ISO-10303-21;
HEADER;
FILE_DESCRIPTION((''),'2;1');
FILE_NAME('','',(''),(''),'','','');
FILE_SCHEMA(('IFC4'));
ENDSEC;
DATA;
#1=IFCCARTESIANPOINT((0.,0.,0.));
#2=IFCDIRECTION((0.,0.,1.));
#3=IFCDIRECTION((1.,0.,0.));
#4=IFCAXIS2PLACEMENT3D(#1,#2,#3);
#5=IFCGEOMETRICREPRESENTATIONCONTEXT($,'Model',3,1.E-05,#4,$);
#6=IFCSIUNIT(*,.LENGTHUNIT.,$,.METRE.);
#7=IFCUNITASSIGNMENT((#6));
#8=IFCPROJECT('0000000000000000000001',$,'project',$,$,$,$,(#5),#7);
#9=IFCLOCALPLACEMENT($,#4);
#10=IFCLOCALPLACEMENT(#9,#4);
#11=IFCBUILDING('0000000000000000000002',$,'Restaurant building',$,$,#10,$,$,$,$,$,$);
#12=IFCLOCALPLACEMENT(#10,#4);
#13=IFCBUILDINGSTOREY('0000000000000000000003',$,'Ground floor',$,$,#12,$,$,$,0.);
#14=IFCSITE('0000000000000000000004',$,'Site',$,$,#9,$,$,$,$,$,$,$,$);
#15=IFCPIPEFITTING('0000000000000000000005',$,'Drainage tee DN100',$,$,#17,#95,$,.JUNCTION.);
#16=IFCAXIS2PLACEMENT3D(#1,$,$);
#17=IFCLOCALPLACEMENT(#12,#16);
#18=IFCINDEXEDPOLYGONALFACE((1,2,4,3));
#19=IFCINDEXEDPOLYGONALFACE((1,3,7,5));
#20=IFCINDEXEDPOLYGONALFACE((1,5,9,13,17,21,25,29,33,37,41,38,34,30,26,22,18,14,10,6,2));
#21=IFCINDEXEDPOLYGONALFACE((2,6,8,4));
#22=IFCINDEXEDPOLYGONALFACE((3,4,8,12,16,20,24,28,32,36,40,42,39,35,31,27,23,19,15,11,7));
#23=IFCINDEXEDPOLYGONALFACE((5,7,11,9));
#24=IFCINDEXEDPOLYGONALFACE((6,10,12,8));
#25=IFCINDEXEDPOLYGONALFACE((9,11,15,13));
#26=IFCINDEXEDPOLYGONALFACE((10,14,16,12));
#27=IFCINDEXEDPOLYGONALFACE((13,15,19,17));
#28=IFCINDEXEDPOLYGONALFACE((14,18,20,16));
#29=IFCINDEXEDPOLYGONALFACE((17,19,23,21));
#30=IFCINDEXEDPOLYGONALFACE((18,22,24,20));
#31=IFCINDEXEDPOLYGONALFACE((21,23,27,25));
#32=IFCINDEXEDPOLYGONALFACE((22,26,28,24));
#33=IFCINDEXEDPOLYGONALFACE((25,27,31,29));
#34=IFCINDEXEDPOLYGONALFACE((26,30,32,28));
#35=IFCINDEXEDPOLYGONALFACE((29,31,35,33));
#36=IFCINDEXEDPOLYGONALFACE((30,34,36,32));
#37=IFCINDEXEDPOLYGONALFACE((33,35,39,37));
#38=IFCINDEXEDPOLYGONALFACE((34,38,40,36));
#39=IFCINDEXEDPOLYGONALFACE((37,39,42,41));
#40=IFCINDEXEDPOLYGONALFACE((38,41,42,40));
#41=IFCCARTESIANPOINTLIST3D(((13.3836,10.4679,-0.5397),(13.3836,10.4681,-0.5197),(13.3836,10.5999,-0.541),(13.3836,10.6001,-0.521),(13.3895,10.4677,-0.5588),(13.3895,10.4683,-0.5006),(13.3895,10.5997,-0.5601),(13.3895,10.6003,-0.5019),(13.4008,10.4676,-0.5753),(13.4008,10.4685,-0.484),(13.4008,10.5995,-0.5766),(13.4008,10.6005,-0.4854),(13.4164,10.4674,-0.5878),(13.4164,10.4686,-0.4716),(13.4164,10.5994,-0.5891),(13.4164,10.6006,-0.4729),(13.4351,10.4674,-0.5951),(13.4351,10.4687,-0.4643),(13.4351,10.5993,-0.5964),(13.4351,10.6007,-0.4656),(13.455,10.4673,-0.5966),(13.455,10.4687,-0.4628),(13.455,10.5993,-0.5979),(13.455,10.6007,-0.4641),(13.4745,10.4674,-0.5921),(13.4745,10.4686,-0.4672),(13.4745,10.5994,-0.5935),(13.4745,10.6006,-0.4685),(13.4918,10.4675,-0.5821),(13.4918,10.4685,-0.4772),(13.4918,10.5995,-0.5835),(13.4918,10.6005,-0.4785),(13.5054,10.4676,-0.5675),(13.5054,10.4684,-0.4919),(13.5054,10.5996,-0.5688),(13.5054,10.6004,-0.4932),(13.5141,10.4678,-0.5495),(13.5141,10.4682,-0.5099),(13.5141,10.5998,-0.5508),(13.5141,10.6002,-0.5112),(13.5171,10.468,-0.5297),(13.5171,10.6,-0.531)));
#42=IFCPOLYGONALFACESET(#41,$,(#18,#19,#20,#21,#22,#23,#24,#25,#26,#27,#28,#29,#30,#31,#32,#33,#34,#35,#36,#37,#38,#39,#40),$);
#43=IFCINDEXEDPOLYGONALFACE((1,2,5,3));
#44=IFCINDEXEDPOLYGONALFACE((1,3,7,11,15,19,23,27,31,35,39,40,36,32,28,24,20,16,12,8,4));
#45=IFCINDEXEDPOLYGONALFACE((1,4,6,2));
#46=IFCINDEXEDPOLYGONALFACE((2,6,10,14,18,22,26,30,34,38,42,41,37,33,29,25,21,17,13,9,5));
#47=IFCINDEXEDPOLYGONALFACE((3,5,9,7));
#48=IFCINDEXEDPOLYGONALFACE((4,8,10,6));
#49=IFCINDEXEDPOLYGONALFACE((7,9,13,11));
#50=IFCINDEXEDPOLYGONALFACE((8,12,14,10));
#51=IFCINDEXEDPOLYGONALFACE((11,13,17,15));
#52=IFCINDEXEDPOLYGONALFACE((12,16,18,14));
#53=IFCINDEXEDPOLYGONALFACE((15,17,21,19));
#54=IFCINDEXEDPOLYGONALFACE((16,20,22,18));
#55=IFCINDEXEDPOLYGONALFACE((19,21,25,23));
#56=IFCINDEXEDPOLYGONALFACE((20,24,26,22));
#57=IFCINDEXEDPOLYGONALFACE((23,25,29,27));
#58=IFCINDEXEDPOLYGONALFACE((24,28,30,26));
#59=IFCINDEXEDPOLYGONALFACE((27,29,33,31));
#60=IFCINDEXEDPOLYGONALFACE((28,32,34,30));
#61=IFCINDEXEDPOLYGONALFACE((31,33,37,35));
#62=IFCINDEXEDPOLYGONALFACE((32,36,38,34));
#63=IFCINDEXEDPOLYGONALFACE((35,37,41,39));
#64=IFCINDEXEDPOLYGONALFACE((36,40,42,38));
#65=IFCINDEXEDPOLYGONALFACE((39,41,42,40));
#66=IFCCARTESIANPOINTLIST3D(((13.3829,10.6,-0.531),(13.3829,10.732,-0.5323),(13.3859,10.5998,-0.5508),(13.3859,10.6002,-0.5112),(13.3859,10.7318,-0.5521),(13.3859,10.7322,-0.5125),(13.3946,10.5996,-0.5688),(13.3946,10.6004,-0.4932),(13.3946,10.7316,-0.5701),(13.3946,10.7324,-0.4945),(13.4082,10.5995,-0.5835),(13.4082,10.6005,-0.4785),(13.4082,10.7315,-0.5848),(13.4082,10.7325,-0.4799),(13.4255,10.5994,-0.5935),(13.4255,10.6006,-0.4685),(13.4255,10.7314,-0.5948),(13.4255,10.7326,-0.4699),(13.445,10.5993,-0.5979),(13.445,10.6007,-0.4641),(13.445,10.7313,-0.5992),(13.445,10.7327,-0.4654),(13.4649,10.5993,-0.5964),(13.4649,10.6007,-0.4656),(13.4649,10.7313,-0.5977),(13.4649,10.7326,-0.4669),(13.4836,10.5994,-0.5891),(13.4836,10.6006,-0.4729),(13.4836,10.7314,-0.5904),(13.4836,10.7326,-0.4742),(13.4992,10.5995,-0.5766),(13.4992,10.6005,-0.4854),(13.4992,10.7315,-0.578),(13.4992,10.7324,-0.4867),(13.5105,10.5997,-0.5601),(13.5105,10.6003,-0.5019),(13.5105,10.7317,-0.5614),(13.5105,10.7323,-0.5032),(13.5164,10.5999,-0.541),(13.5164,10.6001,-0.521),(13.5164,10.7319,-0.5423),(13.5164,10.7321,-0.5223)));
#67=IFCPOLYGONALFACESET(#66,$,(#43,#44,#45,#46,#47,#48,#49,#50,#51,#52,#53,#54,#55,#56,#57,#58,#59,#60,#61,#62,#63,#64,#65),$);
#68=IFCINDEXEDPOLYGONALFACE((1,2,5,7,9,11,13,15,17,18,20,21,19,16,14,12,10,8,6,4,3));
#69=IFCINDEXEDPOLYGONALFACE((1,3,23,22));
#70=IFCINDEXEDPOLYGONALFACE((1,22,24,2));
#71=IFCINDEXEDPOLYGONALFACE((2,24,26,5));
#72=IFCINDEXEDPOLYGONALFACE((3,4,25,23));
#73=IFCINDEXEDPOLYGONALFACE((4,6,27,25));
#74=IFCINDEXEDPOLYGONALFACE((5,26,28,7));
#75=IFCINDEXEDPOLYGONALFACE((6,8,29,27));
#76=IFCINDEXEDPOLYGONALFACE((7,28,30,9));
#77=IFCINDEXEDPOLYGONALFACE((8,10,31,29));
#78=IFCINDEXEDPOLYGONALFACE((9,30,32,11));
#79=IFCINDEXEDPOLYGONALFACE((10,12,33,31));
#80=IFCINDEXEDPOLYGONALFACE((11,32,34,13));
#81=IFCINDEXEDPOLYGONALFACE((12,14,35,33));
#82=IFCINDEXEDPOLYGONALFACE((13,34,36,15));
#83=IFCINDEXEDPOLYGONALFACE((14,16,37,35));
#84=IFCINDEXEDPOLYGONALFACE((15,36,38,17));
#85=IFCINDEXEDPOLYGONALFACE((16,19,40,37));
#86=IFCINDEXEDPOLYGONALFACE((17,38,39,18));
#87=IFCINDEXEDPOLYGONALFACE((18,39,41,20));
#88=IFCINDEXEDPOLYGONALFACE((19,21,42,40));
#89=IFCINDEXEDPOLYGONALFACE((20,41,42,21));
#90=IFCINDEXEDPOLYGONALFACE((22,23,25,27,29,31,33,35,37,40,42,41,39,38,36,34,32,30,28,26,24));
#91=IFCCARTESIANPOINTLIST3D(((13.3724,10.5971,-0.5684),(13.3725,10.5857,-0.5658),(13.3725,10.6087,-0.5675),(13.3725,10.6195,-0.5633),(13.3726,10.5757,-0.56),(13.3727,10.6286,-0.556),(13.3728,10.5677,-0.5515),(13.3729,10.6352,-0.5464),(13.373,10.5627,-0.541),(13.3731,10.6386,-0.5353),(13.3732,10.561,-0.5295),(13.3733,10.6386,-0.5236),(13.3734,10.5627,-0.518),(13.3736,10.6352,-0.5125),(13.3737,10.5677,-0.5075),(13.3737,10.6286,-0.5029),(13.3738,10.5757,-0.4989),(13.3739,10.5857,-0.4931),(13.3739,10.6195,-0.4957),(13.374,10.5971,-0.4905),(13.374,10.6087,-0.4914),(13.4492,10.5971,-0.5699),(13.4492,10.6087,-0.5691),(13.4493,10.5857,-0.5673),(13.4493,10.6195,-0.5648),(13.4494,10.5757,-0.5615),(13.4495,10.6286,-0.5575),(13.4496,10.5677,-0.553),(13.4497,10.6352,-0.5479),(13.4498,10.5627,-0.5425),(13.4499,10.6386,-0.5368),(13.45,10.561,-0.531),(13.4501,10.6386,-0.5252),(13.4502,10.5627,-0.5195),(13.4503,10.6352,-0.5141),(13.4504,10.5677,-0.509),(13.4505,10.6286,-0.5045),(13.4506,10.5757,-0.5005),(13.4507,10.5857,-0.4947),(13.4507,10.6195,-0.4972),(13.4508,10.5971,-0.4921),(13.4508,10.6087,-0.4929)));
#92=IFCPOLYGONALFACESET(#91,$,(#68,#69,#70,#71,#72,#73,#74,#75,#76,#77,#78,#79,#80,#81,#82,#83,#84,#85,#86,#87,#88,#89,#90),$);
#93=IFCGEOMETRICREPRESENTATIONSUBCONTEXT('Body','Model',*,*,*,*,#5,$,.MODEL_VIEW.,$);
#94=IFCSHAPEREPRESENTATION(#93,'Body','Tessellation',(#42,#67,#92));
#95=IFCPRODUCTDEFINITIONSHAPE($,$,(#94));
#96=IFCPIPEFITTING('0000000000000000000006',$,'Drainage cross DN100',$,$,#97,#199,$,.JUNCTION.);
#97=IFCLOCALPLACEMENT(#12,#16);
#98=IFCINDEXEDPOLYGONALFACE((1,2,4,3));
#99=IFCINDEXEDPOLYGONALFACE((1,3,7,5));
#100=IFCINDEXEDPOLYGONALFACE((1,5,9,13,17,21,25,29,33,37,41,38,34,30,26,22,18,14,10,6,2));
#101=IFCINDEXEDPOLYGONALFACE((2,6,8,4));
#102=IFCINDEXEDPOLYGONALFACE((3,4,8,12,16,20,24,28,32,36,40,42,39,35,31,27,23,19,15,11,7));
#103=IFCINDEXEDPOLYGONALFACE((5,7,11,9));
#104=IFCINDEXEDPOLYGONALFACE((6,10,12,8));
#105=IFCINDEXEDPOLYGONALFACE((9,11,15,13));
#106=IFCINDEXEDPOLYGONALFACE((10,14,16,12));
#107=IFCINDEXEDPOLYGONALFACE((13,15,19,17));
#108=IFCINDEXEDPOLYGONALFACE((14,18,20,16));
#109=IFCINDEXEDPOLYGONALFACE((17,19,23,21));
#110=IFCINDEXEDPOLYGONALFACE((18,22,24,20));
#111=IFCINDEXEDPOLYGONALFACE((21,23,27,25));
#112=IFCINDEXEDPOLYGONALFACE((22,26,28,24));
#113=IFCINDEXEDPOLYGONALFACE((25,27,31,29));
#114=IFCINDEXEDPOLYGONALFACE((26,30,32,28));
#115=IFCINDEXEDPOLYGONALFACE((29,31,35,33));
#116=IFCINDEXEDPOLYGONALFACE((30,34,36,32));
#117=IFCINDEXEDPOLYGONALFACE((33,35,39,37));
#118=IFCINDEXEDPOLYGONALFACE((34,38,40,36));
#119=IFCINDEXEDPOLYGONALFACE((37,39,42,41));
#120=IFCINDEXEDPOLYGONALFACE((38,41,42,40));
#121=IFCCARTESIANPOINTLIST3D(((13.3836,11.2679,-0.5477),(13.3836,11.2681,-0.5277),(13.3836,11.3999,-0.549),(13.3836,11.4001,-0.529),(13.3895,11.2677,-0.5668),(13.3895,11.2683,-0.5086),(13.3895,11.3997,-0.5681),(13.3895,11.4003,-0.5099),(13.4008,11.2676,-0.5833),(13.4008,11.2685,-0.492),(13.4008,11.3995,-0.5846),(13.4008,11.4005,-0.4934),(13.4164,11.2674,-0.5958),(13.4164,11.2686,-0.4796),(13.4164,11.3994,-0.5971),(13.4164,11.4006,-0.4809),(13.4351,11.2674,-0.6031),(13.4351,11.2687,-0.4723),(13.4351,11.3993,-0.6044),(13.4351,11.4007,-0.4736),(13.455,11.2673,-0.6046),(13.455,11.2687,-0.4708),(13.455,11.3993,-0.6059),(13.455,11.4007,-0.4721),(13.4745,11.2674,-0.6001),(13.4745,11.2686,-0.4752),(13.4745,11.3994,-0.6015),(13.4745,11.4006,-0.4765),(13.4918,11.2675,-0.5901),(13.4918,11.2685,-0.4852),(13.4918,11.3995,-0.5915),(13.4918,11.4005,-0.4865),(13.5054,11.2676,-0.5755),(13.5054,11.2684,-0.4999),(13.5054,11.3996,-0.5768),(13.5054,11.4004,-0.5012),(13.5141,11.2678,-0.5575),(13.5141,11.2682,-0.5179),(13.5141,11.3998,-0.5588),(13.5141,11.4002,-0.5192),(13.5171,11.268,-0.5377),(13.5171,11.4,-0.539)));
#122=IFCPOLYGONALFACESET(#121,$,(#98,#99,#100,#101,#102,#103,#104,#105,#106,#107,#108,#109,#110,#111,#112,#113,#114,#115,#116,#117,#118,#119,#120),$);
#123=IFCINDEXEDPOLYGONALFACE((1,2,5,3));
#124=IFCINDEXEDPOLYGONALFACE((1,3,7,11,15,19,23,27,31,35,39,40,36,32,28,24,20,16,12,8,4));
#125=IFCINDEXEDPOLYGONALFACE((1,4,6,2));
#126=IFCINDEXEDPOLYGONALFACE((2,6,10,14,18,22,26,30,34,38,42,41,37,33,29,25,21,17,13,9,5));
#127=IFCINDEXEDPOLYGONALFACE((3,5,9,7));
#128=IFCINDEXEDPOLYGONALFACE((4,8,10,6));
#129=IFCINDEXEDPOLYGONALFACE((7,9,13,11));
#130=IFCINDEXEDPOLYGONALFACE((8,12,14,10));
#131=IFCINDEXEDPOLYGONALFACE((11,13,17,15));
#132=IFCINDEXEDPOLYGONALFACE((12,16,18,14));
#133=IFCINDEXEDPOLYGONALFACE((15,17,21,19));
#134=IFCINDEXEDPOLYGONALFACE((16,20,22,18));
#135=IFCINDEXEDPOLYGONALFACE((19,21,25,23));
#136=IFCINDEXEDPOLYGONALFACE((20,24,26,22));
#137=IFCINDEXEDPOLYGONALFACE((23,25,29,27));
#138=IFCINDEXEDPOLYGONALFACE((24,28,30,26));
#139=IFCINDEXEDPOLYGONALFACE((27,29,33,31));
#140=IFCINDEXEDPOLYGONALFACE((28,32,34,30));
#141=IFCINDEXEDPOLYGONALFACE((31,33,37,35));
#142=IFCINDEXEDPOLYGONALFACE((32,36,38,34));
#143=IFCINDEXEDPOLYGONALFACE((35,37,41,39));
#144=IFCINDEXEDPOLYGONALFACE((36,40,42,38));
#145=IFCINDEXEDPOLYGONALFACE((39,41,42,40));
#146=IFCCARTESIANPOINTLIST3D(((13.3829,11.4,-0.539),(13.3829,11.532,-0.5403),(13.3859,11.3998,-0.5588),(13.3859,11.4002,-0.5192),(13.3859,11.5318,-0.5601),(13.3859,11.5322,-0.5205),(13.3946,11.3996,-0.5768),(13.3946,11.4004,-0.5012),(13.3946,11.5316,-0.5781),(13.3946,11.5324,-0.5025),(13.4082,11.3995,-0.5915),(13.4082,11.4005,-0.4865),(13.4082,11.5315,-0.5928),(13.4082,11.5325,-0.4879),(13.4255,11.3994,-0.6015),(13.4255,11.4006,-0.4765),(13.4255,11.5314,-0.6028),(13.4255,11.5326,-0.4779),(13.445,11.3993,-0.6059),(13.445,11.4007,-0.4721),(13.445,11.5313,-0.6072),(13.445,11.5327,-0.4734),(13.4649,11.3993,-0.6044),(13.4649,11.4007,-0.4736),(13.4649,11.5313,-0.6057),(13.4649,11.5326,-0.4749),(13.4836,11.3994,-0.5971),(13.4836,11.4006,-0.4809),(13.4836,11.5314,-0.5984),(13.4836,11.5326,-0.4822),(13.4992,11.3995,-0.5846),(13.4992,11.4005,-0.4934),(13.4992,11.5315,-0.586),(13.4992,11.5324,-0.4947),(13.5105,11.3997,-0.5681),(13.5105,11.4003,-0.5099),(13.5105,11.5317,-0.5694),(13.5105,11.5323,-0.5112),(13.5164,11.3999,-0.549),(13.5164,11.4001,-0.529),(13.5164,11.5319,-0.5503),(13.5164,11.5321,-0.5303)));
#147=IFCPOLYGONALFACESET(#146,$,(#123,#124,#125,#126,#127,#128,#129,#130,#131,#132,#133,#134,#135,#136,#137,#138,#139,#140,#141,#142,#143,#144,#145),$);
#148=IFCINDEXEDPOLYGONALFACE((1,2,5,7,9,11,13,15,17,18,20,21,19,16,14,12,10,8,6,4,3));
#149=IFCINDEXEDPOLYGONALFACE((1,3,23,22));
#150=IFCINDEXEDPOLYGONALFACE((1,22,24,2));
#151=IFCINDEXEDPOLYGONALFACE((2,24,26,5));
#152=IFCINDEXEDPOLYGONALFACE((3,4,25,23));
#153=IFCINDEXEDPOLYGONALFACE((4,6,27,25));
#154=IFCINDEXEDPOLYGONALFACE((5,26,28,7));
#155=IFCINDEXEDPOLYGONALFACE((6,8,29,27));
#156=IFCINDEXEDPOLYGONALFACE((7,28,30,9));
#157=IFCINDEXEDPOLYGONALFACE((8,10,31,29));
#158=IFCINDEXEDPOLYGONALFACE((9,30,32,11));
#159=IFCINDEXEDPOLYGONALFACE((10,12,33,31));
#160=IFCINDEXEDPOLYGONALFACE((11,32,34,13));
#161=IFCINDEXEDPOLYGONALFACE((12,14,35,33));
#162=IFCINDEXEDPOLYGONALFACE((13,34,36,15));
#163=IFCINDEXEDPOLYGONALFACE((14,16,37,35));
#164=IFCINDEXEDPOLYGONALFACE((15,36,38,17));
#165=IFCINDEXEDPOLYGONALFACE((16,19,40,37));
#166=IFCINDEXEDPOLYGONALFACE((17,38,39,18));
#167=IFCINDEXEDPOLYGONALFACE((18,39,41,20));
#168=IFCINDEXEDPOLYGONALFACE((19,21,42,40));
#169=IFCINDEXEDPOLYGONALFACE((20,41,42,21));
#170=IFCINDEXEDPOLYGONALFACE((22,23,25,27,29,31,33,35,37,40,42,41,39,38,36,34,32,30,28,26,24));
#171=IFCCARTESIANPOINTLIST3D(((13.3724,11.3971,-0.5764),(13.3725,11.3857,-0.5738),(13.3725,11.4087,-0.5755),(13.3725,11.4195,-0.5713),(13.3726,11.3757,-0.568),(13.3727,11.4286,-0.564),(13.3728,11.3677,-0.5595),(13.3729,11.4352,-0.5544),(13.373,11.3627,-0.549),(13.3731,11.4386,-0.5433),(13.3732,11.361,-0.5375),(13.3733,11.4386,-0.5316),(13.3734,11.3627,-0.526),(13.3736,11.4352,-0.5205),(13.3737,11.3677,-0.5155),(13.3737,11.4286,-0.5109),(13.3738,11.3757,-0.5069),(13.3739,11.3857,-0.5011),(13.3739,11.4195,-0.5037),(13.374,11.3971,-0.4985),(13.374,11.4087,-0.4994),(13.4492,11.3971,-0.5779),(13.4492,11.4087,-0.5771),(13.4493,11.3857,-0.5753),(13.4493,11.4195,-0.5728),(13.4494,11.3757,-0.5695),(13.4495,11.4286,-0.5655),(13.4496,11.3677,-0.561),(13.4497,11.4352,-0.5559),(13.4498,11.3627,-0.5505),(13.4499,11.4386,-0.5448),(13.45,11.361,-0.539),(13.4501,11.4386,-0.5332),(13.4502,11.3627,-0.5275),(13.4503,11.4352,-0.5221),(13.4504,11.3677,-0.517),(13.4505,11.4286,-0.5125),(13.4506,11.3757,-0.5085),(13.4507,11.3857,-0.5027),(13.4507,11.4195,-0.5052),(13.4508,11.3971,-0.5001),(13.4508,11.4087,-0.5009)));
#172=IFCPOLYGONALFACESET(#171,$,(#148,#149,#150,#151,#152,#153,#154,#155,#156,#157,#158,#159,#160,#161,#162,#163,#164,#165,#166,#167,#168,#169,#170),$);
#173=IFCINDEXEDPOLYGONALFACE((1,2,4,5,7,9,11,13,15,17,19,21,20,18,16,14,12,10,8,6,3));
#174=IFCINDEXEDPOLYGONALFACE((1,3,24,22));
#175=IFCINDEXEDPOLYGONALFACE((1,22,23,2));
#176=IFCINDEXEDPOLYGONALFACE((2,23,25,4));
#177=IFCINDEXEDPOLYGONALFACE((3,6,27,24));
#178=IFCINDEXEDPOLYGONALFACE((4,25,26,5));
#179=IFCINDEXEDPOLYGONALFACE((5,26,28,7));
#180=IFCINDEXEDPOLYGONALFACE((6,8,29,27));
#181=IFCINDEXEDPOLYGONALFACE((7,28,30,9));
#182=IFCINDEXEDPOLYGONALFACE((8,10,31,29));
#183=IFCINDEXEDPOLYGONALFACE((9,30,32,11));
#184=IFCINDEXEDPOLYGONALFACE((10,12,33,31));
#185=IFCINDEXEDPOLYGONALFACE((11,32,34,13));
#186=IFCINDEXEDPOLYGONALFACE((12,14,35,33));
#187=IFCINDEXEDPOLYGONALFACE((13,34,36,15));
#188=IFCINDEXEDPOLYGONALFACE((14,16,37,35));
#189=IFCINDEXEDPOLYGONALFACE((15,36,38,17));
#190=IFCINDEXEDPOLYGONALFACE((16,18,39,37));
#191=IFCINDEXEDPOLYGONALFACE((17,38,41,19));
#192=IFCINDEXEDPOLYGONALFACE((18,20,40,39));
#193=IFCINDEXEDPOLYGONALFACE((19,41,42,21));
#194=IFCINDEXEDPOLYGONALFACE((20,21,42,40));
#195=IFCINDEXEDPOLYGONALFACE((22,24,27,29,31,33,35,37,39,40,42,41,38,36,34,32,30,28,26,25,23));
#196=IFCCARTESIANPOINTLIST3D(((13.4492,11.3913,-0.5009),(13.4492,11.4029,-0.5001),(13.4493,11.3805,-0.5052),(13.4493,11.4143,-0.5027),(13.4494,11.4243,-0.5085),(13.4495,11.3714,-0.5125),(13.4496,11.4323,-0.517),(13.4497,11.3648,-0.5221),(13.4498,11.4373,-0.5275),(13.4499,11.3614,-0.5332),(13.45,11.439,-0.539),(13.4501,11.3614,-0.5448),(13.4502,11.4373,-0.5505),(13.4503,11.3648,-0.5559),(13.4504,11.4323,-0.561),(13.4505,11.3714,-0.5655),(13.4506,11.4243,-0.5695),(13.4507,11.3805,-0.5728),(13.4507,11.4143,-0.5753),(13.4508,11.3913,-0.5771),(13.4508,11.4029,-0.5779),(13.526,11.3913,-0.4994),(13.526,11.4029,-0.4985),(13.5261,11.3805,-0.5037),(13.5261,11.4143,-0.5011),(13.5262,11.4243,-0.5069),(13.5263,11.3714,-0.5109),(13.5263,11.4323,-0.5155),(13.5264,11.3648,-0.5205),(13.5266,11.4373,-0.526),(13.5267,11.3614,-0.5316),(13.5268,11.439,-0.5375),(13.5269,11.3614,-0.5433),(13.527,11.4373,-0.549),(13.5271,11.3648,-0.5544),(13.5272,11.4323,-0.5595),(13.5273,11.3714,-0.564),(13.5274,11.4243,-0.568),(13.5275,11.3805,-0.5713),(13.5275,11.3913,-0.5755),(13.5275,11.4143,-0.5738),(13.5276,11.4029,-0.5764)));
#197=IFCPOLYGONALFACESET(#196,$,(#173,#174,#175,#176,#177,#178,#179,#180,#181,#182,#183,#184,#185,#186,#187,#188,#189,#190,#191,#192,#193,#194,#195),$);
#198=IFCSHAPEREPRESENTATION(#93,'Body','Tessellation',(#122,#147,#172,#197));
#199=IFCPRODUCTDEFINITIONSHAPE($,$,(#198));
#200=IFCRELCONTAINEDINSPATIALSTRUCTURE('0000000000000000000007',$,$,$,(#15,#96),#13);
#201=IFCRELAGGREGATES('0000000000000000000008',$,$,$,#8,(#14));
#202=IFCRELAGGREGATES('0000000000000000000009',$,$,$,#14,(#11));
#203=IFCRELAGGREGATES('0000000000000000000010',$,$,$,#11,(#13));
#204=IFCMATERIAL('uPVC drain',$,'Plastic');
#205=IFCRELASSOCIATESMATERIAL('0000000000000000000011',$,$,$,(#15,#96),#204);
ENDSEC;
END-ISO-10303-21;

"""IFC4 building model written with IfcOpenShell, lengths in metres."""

from ifc_helpers import new_model, si_unit, frame, origin_with_axes, origin_2d, place, context, subcontext, project, spatial, circle, extrude, material, element, save


model = new_model("IFC4")

# Units and contexts
model_context = context("Model", 3, precision=1e-05, world=origin_with_axes())
body_context = subcontext(model_context, "Body", "Model", "MODEL_VIEW")
ifc_project = project(units=[si_unit("LENGTHUNIT", "METRE")], contexts=[model_context])

# Site, building, storey
site_placement = place(None, origin_with_axes())
site = spatial("IfcSite", under=ifc_project, at=site_placement, Name="Site")
building_placement = place(site_placement, origin_with_axes())
building = spatial("IfcBuilding", under=site, at=building_placement, Name="Restaurant building")
storey_placement = place(building_placement, origin_with_axes())
storey = spatial("IfcBuildingStorey", under=building, at=storey_placement, Name="Ground floor", Elevation=0.0)

# Shared definitions
ifc_material_1 = material(Name="uPVC drain", Category="Plastic")

# Pipe fittings
pipe_fitting_1_placement = place(storey_placement, frame((13.45, 10.6, -0.531)))
element("IfcPipeFitting", 1, at=pipe_fitting_1_placement, inside=storey, material=ifc_material_1, Name="Drainage tee DN100", PredefinedType="JUNCTION", context=body_context, shape_type="SweptSolid", body=[
    extrude(circle(Radius=0.0671, at=origin_2d()), frame((0.0, 0.0, 0.0), z_axis=(0.0, -0.99995, 0.009999), x_axis=(1.0, 0.0, 0.0)), (0.0, 0.0, 1.0), 0.132),
    extrude(circle(Radius=0.0671, at=origin_2d()), frame((0.0, 0.0, 0.0), z_axis=(0.0, 0.99995, -0.009999), x_axis=(-1.0, 0.0, 0.0)), (0.0, 0.0, 1.0), 0.132),
    extrude(circle(Radius=0.039, at=origin_2d()), frame((0.0, 0.0, 0.0), z_axis=(-0.9998, 0.0, 0.019996), x_axis=(0.0, -1.0, 0.0)), (0.0, 0.0, 1.0), 0.0768),
])
pipe_fitting_2_placement = place(storey_placement, frame((13.45, 11.4, -0.539)))
element("IfcPipeFitting", 2, at=pipe_fitting_2_placement, inside=storey, material=ifc_material_1, Name="Drainage cross DN100", PredefinedType="JUNCTION", context=body_context, shape_type="SweptSolid", body=[
    extrude(circle(Radius=0.0671, at=origin_2d()), frame((0.0, 0.0, 0.0), z_axis=(0.0, -0.99995, 0.009999), x_axis=(1.0, 0.0, 0.0)), (0.0, 0.0, 1.0), 0.132),
    extrude(circle(Radius=0.0671, at=origin_2d()), frame((0.0, 0.0, 0.0), z_axis=(0.0, 0.99995, -0.009999), x_axis=(-1.0, 0.0, 0.0)), (0.0, 0.0, 1.0), 0.132),
    extrude(circle(Radius=0.039, at=origin_2d()), frame((0.0, 0.0, 0.0), z_axis=(-0.9998, 0.0, 0.019996), x_axis=(0.0, -1.0, 0.0)), (0.0, 0.0, 1.0), 0.0768),
    extrude(circle(Radius=0.039, at=origin_2d()), frame((0.0, 0.0, 0.0), z_axis=(0.9998, 0.0, 0.019996), x_axis=(0.0, 1.0, 0.0)), (0.0, 0.0, 1.0), 0.0768),
])

save(model, "model.ifc")
